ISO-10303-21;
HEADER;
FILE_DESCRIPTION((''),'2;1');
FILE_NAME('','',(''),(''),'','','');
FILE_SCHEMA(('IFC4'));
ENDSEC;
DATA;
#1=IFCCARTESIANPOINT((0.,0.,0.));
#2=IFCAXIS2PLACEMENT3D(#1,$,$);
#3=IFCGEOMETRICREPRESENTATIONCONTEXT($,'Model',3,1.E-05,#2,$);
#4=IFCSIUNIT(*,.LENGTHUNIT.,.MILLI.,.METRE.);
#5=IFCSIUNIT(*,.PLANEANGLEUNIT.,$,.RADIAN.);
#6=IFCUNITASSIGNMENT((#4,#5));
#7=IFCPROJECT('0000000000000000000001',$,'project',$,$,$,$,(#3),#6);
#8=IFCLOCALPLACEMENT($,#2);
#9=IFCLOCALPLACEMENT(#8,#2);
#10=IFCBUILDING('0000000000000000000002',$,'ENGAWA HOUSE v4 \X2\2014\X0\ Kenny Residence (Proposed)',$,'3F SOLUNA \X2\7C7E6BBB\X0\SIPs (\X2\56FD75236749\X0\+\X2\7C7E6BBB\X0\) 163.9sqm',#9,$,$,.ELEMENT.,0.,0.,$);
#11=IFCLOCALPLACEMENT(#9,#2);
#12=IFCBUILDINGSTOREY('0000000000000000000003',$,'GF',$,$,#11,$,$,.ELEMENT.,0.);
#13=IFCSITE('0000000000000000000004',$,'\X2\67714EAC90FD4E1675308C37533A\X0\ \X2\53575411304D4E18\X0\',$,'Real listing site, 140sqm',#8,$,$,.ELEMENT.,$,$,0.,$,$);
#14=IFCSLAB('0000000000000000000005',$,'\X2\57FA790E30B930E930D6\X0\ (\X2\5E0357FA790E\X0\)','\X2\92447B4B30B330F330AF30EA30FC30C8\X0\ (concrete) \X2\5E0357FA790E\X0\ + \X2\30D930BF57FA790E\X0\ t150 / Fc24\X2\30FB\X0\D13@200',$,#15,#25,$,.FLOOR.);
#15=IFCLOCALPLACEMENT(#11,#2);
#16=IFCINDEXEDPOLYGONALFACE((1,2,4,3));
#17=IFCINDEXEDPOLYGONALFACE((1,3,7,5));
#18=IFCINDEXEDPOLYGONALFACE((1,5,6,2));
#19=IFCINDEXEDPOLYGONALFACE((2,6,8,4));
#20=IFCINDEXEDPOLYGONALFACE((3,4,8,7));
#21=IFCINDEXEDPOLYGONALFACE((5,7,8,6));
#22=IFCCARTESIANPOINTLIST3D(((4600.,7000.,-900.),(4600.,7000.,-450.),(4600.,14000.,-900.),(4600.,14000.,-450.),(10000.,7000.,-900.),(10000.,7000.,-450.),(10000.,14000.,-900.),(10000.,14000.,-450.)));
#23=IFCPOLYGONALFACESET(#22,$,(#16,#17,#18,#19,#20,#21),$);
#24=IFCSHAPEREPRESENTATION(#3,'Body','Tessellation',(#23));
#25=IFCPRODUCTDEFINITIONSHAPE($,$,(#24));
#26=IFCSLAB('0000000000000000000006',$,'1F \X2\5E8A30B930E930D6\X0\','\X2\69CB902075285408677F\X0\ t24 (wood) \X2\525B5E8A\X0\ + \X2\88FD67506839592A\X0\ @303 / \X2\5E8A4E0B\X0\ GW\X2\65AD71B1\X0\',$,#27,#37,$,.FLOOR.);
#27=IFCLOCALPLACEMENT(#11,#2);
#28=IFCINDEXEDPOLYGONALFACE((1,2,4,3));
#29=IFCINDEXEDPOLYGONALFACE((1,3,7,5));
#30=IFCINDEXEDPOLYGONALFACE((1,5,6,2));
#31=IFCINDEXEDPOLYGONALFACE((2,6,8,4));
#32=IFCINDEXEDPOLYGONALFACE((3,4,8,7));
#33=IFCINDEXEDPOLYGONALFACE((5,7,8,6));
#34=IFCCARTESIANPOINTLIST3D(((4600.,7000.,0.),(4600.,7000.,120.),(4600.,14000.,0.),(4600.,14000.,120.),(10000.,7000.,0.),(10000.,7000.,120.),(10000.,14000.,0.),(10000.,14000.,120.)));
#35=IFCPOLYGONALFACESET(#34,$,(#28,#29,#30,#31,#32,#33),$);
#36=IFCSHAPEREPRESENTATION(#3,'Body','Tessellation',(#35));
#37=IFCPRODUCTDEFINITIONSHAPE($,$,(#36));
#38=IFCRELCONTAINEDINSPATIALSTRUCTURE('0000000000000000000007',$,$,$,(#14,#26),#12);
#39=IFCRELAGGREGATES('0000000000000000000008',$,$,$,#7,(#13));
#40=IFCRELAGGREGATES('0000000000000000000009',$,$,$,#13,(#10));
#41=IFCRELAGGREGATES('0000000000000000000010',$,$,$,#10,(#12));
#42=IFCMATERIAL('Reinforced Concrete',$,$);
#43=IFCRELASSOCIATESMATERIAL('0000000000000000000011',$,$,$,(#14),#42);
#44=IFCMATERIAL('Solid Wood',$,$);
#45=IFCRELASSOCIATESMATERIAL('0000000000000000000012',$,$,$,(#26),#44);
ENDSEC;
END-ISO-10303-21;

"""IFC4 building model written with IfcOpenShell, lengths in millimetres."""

from ifc_helpers import new_model, si_unit, frame, frame_2d, origin, place, context, project, spatial, rectangle, extrude, material, element, save


model = new_model("IFC4")

# Units and contexts
model_context = context("Model", 3, precision=1e-05, world=origin())
ifc_project = project(units=[si_unit("LENGTHUNIT", "METRE", prefix="MILLI"), si_unit("PLANEANGLEUNIT", "RADIAN")], contexts=[model_context])

# Site, building, storey
site_placement = place(None, origin())
site = spatial("IfcSite", under=ifc_project, at=site_placement, Name="東京都世田谷区 南向き丘", ObjectType="Real listing site, 140sqm", CompositionType="ELEMENT", RefElevation=0.0)
building_placement = place(site_placement, origin())
building = spatial("IfcBuilding", under=site, at=building_placement, Name="ENGAWA HOUSE v4 — Kenny Residence (Proposed)", ObjectType="3F SOLUNA 籾殻SIPs (国産杉+籾殻) 163.9sqm", CompositionType="ELEMENT", ElevationOfRefHeight=0.0, ElevationOfTerrain=0.0)
storey_placement = place(building_placement, origin())
storey = spatial("IfcBuildingStorey", under=building, at=storey_placement, Name="GF", CompositionType="ELEMENT", Elevation=0.0)

# Slabs
ifc_material_1 = material(Name="Reinforced Concrete")
slab_1_placement = place(storey_placement, frame((2300.0, 3500.0, -450.0)))
element("IfcSlab", 1, at=slab_1_placement, inside=storey, material=ifc_material_1, Name="基礎スラブ (布基礎)", Description="鉄筋コンクリート (concrete) 布基礎 + ベタ基礎 t150 / Fc24・D13@200", PredefinedType="FLOOR", context=model_context, shape_type="SweptSolid", body=[
    extrude(rectangle(XDim=5400.0, YDim=7000.0, at=frame_2d((2700.0, 3500.0))), frame((2300.0, 3500.0, -450.0)), (0.0, 0.0, 1.0), 450.0),
])
ifc_material_2 = material(Name="Solid Wood")
slab_2_placement = place(storey_placement, frame((2300.0, 3500.0, 0.0)))
element("IfcSlab", 2, at=slab_2_placement, inside=storey, material=ifc_material_2, Name="1F 床スラブ", Description="構造用合板 t24 (wood) 剛床 + 製材根太 @303 / 床下 GW断熱", PredefinedType="FLOOR", context=model_context, shape_type="SweptSolid", body=[
    extrude(rectangle(XDim=5400.0, YDim=7000.0, at=frame_2d((2700.0, 3500.0))), frame((2300.0, 3500.0, 0.0)), (0.0, 0.0, 1.0), 120.0),
])

save(model, "model.ifc")
